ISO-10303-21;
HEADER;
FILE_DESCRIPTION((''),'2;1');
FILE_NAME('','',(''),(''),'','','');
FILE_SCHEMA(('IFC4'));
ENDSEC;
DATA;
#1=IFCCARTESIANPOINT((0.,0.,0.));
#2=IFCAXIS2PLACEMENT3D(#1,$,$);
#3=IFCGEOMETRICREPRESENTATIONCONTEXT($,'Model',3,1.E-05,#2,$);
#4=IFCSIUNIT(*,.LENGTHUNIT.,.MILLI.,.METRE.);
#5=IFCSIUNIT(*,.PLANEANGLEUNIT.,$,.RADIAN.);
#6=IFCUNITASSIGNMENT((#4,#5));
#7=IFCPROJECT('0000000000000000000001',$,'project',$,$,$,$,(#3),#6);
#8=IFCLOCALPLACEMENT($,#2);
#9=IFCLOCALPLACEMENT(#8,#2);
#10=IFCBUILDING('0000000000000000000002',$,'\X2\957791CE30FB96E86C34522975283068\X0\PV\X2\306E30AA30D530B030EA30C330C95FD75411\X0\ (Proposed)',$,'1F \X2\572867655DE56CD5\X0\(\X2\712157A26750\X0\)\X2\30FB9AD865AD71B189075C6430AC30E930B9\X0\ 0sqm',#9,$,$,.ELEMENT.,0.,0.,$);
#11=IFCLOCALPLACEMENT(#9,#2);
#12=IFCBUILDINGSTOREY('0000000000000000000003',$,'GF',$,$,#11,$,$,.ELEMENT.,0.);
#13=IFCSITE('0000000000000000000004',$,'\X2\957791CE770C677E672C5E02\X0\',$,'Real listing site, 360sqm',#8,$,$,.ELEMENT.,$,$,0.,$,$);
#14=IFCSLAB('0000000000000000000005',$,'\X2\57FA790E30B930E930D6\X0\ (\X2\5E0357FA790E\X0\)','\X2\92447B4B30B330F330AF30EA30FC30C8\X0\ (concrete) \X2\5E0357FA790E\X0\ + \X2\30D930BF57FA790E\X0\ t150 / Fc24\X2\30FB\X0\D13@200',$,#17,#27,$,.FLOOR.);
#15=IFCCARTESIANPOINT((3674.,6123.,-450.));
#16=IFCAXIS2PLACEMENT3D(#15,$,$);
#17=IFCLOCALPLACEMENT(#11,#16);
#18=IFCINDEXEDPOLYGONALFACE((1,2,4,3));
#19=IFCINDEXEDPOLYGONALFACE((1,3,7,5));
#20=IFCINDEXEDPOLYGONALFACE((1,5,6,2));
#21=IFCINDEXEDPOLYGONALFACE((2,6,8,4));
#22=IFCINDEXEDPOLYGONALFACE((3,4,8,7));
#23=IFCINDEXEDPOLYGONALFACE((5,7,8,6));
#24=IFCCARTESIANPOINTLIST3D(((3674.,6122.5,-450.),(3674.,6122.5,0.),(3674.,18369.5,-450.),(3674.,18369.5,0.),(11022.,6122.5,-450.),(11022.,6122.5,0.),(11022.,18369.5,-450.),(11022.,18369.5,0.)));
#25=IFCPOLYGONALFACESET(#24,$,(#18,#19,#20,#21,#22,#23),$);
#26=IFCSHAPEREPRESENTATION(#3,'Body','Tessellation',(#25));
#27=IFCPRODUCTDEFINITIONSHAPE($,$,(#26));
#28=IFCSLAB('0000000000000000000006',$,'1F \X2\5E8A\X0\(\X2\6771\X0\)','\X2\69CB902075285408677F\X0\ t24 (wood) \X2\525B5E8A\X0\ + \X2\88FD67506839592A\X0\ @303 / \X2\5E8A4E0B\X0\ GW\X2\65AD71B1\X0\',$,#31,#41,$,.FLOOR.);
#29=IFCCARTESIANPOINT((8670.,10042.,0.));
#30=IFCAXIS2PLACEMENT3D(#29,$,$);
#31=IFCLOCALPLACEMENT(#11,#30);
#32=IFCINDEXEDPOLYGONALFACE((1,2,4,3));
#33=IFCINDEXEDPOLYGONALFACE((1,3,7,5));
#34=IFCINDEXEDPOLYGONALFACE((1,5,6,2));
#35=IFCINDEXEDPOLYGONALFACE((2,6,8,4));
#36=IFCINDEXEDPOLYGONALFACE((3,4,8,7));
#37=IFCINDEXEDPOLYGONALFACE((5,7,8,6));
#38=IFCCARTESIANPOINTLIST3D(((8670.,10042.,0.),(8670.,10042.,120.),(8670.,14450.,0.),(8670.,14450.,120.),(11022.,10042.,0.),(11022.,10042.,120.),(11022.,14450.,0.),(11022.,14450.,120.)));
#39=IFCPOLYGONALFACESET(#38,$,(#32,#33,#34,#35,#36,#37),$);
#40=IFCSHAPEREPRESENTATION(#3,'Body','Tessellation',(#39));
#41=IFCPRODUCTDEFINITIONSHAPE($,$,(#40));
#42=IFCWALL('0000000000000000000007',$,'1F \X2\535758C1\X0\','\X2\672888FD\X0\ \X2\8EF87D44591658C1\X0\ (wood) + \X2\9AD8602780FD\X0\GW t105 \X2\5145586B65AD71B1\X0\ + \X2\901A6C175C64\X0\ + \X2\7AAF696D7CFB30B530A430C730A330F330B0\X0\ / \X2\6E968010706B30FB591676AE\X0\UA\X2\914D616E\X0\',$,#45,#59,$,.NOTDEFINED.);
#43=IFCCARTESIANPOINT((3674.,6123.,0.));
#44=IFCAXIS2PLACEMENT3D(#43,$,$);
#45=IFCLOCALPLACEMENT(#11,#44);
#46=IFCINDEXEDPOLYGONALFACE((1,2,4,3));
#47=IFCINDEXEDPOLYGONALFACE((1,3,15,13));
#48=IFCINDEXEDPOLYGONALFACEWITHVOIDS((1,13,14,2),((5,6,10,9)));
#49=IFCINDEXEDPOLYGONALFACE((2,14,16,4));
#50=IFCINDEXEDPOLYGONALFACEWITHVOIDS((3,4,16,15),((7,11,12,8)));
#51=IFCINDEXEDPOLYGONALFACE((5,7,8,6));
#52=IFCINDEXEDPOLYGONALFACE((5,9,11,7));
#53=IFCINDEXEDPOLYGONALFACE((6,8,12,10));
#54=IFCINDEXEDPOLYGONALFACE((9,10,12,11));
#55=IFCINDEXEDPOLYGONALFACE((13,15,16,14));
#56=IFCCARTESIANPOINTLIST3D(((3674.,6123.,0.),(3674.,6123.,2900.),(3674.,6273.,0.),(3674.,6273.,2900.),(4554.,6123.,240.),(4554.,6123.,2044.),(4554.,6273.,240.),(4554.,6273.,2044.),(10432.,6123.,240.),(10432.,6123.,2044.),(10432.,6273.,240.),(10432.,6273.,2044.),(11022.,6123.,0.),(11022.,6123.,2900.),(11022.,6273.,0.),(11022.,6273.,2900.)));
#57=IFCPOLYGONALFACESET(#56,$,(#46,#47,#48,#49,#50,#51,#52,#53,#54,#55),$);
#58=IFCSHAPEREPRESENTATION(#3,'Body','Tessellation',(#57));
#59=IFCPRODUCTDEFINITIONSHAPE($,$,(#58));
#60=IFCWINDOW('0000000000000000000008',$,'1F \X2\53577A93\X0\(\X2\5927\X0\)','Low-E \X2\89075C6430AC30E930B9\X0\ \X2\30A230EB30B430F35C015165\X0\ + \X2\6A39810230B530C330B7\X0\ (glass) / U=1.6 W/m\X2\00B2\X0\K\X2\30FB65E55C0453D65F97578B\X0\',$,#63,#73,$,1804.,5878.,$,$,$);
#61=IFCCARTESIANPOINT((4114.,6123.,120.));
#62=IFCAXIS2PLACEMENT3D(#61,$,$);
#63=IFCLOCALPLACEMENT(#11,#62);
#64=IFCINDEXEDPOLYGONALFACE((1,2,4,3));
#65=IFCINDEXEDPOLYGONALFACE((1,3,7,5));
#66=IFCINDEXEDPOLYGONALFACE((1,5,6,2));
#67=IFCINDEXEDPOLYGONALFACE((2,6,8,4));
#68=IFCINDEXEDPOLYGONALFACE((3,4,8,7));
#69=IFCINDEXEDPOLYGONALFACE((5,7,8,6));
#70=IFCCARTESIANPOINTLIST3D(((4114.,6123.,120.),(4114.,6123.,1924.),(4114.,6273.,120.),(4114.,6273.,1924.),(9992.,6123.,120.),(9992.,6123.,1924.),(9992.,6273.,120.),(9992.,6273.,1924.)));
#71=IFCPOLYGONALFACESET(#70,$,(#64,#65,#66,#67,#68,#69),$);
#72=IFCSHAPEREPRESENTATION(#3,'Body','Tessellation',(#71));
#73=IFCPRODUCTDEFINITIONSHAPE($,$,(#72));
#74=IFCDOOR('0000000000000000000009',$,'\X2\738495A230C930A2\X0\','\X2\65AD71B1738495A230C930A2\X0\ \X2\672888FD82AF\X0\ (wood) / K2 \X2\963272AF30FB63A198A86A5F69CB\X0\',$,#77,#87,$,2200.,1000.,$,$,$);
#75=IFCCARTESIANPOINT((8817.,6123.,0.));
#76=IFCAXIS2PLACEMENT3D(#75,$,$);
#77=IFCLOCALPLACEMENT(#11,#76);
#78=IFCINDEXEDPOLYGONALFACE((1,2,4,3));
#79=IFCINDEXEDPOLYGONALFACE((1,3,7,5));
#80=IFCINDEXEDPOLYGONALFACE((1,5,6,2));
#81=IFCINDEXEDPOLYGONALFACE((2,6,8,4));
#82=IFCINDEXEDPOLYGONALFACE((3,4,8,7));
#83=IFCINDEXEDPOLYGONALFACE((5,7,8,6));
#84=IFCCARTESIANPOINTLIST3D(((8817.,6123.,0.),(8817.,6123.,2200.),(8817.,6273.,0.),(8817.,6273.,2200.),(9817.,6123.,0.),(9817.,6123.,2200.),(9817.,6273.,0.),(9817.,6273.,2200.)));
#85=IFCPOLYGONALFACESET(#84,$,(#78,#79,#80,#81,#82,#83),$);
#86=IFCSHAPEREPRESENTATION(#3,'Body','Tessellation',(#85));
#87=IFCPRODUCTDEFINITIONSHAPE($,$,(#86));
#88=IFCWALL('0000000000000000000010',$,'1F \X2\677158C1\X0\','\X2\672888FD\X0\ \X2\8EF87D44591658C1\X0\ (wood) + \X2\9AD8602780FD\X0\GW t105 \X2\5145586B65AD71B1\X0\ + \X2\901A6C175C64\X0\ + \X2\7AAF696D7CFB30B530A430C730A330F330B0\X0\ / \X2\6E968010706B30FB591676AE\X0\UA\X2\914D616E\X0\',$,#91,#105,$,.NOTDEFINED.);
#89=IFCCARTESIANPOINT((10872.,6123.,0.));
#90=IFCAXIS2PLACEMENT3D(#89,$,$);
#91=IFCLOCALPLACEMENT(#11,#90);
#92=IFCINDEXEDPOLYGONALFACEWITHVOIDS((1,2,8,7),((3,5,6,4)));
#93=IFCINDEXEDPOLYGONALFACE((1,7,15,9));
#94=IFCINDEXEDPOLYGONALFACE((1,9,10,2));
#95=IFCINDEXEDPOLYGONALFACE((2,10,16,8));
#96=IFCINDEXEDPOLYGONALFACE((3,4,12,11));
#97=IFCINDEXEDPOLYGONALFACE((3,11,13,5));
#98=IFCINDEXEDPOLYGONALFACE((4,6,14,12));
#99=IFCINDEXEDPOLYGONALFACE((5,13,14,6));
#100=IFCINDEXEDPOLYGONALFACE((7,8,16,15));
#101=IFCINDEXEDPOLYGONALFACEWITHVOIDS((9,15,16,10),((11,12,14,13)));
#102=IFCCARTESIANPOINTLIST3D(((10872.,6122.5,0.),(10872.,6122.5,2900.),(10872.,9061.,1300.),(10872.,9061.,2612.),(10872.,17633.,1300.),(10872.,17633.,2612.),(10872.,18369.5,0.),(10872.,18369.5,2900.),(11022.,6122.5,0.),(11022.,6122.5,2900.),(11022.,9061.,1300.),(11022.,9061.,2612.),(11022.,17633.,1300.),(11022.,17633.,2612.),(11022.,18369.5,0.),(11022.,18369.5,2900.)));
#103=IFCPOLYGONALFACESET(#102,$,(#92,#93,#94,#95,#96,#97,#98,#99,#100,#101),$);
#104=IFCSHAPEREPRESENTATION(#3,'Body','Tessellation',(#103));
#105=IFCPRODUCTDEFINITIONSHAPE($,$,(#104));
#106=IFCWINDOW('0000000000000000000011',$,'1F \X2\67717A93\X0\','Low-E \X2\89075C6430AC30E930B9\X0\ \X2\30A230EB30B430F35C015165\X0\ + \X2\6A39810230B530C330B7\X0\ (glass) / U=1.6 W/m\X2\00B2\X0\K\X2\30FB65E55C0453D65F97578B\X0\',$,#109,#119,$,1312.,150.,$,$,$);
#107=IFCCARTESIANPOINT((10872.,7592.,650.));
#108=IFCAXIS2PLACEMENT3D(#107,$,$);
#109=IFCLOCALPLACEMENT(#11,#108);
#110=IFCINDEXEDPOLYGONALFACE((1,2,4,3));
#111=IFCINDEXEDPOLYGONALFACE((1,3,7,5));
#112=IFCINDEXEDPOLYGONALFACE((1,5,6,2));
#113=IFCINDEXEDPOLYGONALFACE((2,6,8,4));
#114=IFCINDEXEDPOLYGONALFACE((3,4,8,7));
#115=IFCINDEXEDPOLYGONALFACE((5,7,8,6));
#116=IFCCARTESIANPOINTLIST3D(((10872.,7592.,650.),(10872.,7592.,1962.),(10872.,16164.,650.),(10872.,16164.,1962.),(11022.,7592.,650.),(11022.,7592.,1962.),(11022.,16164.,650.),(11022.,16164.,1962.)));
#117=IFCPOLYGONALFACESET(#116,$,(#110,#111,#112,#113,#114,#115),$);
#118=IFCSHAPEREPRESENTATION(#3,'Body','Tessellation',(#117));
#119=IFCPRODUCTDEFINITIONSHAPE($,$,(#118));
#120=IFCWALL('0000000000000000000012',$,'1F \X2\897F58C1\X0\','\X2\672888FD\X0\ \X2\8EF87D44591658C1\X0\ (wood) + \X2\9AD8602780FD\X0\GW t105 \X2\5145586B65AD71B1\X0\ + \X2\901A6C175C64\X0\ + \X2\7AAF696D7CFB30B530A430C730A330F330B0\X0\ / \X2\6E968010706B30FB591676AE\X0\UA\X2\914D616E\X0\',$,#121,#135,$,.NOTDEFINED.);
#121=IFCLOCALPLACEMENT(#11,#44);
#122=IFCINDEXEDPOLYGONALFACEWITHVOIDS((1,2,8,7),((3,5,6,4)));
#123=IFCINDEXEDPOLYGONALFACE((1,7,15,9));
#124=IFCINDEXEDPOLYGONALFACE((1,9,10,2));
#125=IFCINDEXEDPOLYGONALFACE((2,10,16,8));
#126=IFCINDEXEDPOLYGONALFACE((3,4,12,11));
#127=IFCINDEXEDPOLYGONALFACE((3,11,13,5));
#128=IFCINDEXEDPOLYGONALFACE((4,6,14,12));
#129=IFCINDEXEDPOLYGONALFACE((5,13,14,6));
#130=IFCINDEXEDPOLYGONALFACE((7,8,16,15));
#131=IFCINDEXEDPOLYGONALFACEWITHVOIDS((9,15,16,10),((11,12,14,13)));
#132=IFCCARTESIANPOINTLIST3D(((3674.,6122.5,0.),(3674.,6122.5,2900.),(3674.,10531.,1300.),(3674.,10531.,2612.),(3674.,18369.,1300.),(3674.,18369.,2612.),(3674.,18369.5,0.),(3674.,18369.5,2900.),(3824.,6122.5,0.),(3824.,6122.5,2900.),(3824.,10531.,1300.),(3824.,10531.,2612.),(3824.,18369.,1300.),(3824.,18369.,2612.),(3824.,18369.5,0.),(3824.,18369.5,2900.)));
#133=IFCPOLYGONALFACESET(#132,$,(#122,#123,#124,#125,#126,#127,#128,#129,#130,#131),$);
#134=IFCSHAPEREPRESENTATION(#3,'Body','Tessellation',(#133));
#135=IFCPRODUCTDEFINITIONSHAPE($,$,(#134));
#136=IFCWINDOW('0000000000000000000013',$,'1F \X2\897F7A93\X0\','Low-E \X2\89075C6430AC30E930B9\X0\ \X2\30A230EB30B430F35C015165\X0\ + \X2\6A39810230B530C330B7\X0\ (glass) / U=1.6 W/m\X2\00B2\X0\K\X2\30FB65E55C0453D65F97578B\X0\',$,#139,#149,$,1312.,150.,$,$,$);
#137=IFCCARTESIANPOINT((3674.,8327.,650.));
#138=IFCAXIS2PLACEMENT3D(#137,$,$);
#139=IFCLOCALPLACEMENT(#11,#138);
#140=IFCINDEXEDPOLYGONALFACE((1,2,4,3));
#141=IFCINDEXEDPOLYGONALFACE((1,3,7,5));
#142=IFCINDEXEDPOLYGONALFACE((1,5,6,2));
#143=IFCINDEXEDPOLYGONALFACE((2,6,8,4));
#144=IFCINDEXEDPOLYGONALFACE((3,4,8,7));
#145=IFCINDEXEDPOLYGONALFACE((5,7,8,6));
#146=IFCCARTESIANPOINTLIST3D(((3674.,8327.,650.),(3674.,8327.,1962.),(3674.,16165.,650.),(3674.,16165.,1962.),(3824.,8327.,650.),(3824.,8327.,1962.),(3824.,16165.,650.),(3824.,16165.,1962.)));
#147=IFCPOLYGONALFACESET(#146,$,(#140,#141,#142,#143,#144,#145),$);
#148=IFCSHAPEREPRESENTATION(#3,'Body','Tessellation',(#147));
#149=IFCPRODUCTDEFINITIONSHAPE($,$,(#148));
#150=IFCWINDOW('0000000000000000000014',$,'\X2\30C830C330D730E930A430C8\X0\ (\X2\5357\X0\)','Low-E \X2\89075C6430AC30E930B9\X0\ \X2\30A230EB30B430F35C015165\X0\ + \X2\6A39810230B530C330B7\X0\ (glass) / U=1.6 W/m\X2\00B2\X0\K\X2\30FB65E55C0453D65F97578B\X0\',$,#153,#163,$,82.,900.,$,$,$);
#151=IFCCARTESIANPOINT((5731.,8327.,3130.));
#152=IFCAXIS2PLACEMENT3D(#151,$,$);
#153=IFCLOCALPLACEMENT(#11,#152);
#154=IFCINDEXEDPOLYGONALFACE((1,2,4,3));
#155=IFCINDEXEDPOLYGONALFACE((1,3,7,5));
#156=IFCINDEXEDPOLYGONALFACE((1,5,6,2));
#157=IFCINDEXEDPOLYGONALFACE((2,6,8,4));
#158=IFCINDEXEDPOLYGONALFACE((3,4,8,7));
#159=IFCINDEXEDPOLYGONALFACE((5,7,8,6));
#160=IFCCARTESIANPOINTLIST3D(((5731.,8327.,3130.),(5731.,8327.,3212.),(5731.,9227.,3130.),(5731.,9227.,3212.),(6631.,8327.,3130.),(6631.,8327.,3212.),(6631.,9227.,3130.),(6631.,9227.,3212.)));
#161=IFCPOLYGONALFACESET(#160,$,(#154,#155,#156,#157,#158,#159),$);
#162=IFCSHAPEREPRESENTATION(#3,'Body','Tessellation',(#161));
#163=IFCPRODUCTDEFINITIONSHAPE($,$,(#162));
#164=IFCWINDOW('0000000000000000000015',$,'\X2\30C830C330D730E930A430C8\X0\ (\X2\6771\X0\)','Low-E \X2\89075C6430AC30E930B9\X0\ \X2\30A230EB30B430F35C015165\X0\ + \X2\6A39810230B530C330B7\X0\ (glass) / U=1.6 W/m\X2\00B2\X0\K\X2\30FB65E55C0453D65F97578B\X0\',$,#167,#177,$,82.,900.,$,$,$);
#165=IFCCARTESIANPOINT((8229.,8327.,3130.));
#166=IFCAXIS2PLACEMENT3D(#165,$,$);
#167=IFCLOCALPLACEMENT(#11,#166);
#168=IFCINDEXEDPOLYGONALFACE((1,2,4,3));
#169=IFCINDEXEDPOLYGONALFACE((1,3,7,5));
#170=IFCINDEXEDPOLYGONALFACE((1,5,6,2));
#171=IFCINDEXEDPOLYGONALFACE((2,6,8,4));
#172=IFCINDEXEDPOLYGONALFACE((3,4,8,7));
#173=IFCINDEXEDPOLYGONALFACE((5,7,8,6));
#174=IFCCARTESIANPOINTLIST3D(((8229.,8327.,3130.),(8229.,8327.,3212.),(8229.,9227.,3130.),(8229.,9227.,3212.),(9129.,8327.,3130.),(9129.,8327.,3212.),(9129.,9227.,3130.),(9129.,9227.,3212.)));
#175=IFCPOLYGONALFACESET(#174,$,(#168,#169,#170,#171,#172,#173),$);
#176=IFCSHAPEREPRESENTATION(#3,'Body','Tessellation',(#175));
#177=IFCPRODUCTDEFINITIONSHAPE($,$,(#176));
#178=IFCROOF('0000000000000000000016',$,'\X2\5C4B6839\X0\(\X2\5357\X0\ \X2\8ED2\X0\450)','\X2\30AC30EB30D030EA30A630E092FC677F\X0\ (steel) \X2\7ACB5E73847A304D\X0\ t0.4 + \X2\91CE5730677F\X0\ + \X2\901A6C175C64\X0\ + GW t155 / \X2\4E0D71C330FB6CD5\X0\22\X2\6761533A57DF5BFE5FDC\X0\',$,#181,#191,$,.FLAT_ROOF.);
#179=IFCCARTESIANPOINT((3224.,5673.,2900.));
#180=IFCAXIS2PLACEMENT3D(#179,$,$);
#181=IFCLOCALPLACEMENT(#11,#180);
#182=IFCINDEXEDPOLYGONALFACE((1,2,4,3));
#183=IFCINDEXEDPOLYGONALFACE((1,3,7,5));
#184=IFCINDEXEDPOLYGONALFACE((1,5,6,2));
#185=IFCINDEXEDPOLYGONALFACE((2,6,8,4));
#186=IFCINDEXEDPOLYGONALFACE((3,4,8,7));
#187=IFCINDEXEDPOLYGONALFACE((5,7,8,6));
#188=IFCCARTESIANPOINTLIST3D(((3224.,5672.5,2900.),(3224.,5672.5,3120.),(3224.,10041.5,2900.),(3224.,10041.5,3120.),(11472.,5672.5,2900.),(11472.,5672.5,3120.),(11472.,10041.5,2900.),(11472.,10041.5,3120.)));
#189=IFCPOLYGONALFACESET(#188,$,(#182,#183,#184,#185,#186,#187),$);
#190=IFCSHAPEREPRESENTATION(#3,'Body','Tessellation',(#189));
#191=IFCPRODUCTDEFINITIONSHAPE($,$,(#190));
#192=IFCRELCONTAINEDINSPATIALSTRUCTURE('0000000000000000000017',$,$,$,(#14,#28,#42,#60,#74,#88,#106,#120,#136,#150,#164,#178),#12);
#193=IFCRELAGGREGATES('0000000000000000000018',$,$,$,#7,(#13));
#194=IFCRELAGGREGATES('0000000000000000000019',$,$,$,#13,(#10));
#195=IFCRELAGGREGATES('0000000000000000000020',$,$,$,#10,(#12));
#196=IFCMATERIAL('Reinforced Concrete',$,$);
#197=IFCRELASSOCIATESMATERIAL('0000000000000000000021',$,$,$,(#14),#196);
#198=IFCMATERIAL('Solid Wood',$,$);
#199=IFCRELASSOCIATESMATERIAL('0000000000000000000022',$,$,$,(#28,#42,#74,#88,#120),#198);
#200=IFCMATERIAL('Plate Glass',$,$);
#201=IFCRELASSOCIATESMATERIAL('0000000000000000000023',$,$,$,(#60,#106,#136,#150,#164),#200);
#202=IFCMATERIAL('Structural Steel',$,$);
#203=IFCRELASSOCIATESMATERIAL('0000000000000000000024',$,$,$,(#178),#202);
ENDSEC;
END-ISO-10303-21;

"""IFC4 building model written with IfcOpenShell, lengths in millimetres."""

from ifc_helpers import new_model, si_unit, frame, frame_2d, origin, place, context, project, spatial, rectangle, extrude, material, element, fill, save


model = new_model("IFC4")

# Units and contexts
model_context = context("Model", 3, precision=1e-05, world=origin())
ifc_project = project(units=[si_unit("LENGTHUNIT", "METRE", prefix="MILLI"), si_unit("PLANEANGLEUNIT", "RADIAN")], contexts=[model_context])

# Site, building, storey
site_placement = place(None, origin())
site = spatial("IfcSite", under=ifc_project, at=site_placement, Name="長野県松本市", ObjectType="Real listing site, 360sqm", CompositionType="ELEMENT", RefElevation=0.0)
building_placement = place(site_placement, origin())
building = spatial("IfcBuilding", under=site, at=building_placement, Name="長野・雨水利用とPVのオフグリッド志向 (Proposed)", ObjectType="1F 在来工法(無垢材)・高断熱複層ガラス 0sqm", CompositionType="ELEMENT", ElevationOfRefHeight=0.0, ElevationOfTerrain=0.0)
storey_placement = place(building_placement, origin())
storey = spatial("IfcBuildingStorey", under=building, at=storey_placement, Name="GF", CompositionType="ELEMENT", Elevation=0.0)

# Slabs
ifc_material_1 = material(Name="Reinforced Concrete")
slab_1_placement = place(storey_placement, frame((3674.0, 6123.0, -450.0)))
element("IfcSlab", 1, at=slab_1_placement, inside=storey, material=ifc_material_1, Name="基礎スラブ (布基礎)", Description="鉄筋コンクリート (concrete) 布基礎 + ベタ基礎 t150 / Fc24・D13@200", PredefinedType="FLOOR", context=model_context, shape_type="SweptSolid", body=[
    extrude(rectangle(XDim=7348.0, YDim=12247.0, at=frame_2d((3674.0, 6123.0))), frame((3674.0, 6123.0, -450.0)), (0.0, 0.0, 1.0), 450.0),
])
ifc_material_2 = material(Name="Solid Wood")
slab_2_placement = place(storey_placement, frame((8670.0, 10042.0, 0.0)))
element("IfcSlab", 2, at=slab_2_placement, inside=storey, material=ifc_material_2, Name="1F 床(東)", Description="構造用合板 t24 (wood) 剛床 + 製材根太 @303 / 床下 GW断熱", PredefinedType="FLOOR", context=model_context, shape_type="SweptSolid", body=[
    extrude(rectangle(XDim=2352.0, YDim=4408.0, at=frame_2d((1176.0, 2204.0))), frame((8670.0, 10042.0, 0.0)), (0.0, 0.0, 1.0), 120.0),
])

# Wall, openings, window, door
wall_1_placement = place(storey_placement, frame((3674.0, 6123.0, 0.0)))
wall_1 = element("IfcWall", 3, at=wall_1_placement, inside=storey, material=ifc_material_2, Name="1F 南壁", Description="木製 軸組外壁 (wood) + 高性能GW t105 充填断熱 + 通気層 + 窯業系サイディング / 準耐火・外皮UA配慮", PredefinedType="NOTDEFINED", context=model_context, shape_type="SweptSolid", body=[
    extrude(rectangle(XDim=7348.0, YDim=150.0, at=frame_2d((3674.0, 75.0))), frame((3674.0, 6123.0, 0.0)), (0.0, 0.0, 1.0), 2900.0),
])
opening_1_placement = place(storey_placement, frame((4114.0, 6123.0, 120.0)))
opening_1 = element("IfcOpeningElement", 4, at=opening_1_placement, cuts=wall_1, PredefinedType="NOTDEFINED", context=model_context, shape_type="SweptSolid", body=[
    extrude(rectangle(XDim=5878.0, YDim=150.0, at=frame_2d((2939.0, 75.0))), frame((4114.0, 6123.0, 120.0)), (0.0, 0.0, 1.0), 1804.0),
])
opening_2_placement = place(storey_placement, frame((8817.0, 6123.0, 0.0)))
opening_2 = element("IfcOpeningElement", 5, at=opening_2_placement, cuts=wall_1, PredefinedType="NOTDEFINED", context=model_context, shape_type="SweptSolid", body=[
    extrude(rectangle(XDim=1000.0, YDim=150.0, at=frame_2d((500.0, 75.0))), frame((8817.0, 6123.0, 0.0)), (0.0, 0.0, 1.0), 2200.0),
])
ifc_material_3 = material(Name="Plate Glass")
window_1_placement = place(storey_placement, frame((4114.0, 6123.0, 120.0)))
window_1 = element("IfcWindow", 6, at=window_1_placement, inside=storey, material=ifc_material_3, Name="1F 南窓(大)", Description="Low-E 複層ガラス アルゴン封入 + 樹脂サッシ (glass) / U=1.6 W/m²K・日射取得型", OverallHeight=1804.0, OverallWidth=5878.0, context=model_context, shape_type="SweptSolid", body=[
    extrude(rectangle(XDim=5878.0, YDim=150.0, at=frame_2d((2939.0, 75.0))), frame((4114.0, 6123.0, 120.0)), (0.0, 0.0, 1.0), 1804.0),
])
fill(opening_1, window_1)
door_placement = place(storey_placement, frame((8817.0, 6123.0, 0.0)))
door = element("IfcDoor", 7, at=door_placement, inside=storey, material=ifc_material_2, Name="玄関ドア", Description="断熱玄関ドア 木製芯 (wood) / K2 防犯・採風機構", OverallHeight=2200.0, OverallWidth=1000.0, context=model_context, shape_type="SweptSolid", body=[
    extrude(rectangle(XDim=1000.0, YDim=150.0, at=frame_2d((500.0, 75.0))), frame((8817.0, 6123.0, 0.0)), (0.0, 0.0, 1.0), 2200.0),
])
fill(opening_2, door)

# Walls, openings, windows
wall_2_placement = place(storey_placement, frame((10872.0, 6123.0, 0.0)))
wall_2 = element("IfcWall", 8, at=wall_2_placement, inside=storey, material=ifc_material_2, Name="1F 東壁", Description="木製 軸組外壁 (wood) + 高性能GW t105 充填断熱 + 通気層 + 窯業系サイディング / 準耐火・外皮UA配慮", PredefinedType="NOTDEFINED", context=model_context, shape_type="SweptSolid", body=[
    extrude(rectangle(XDim=150.0, YDim=12247.0, at=frame_2d((75.0, 6123.0))), frame((10872.0, 6123.0, 0.0)), (0.0, 0.0, 1.0), 2900.0),
])
opening_3_placement = place(storey_placement, frame((10872.0, 7592.0, 650.0)))
opening_3 = element("IfcOpeningElement", 9, at=opening_3_placement, cuts=wall_2, PredefinedType="NOTDEFINED", context=model_context, shape_type="SweptSolid", body=[
    extrude(rectangle(XDim=150.0, YDim=8572.0, at=frame_2d((75.0, 4286.0))), frame((10872.0, 7592.0, 650.0)), (0.0, 0.0, 1.0), 1312.0),
])
window_2_placement = place(storey_placement, frame((10872.0, 7592.0, 650.0)))
window_2 = element("IfcWindow", 10, at=window_2_placement, inside=storey, material=ifc_material_3, Name="1F 東窓", Description="Low-E 複層ガラス アルゴン封入 + 樹脂サッシ (glass) / U=1.6 W/m²K・日射取得型", OverallHeight=1312.0, OverallWidth=150.0, context=model_context, shape_type="SweptSolid", body=[
    extrude(rectangle(XDim=150.0, YDim=8572.0, at=frame_2d((75.0, 4286.0))), frame((10872.0, 7592.0, 650.0)), (0.0, 0.0, 1.0), 1312.0),
])
fill(opening_3, window_2)
wall_3_placement = place(storey_placement, frame((3674.0, 6123.0, 0.0)))
wall_3 = element("IfcWall", 11, at=wall_3_placement, inside=storey, material=ifc_material_2, Name="1F 西壁", Description="木製 軸組外壁 (wood) + 高性能GW t105 充填断熱 + 通気層 + 窯業系サイディング / 準耐火・外皮UA配慮", PredefinedType="NOTDEFINED", context=model_context, shape_type="SweptSolid", body=[
    extrude(rectangle(XDim=150.0, YDim=12247.0, at=frame_2d((75.0, 6123.0))), frame((3674.0, 6123.0, 0.0)), (0.0, 0.0, 1.0), 2900.0),
])
opening_4_placement = place(storey_placement, frame((3674.0, 8327.0, 650.0)))
opening_4 = element("IfcOpeningElement", 12, at=opening_4_placement, cuts=wall_3, PredefinedType="NOTDEFINED", context=model_context, shape_type="SweptSolid", body=[
    extrude(rectangle(XDim=150.0, YDim=7838.0, at=frame_2d((75.0, 3919.0))), frame((3674.0, 8327.0, 650.0)), (0.0, 0.0, 1.0), 1312.0),
])
window_3_placement = place(storey_placement, frame((3674.0, 8327.0, 650.0)))
window_3 = element("IfcWindow", 13, at=window_3_placement, inside=storey, material=ifc_material_3, Name="1F 西窓", Description="Low-E 複層ガラス アルゴン封入 + 樹脂サッシ (glass) / U=1.6 W/m²K・日射取得型", OverallHeight=1312.0, OverallWidth=150.0, context=model_context, shape_type="SweptSolid", body=[
    extrude(rectangle(XDim=150.0, YDim=7838.0, at=frame_2d((75.0, 3919.0))), frame((3674.0, 8327.0, 650.0)), (0.0, 0.0, 1.0), 1312.0),
])
fill(opening_4, window_3)

# Windows
window_4_placement = place(storey_placement, frame((5731.0, 8327.0, 3130.0)))
element("IfcWindow", 14, at=window_4_placement, inside=storey, material=ifc_material_3, Name="トップライト (南)", Description="Low-E 複層ガラス アルゴン封入 + 樹脂サッシ (glass) / U=1.6 W/m²K・日射取得型", OverallHeight=82.0, OverallWidth=900.0, context=model_context, shape_type="SweptSolid", body=[
    extrude(rectangle(XDim=900.0, YDim=900.0, at=frame_2d((450.0, 450.0))), frame((5731.0, 8327.0, 3130.0)), (0.0, 0.0, 1.0), 82.0),
])
window_5_placement = place(storey_placement, frame((8229.0, 8327.0, 3130.0)))
element("IfcWindow", 15, at=window_5_placement, inside=storey, material=ifc_material_3, Name="トップライト (東)", Description="Low-E 複層ガラス アルゴン封入 + 樹脂サッシ (glass) / U=1.6 W/m²K・日射取得型", OverallHeight=82.0, OverallWidth=900.0, context=model_context, shape_type="SweptSolid", body=[
    extrude(rectangle(XDim=900.0, YDim=900.0, at=frame_2d((450.0, 450.0))), frame((8229.0, 8327.0, 3130.0)), (0.0, 0.0, 1.0), 82.0),
])

# Roof
ifc_material_4 = material(Name="Structural Steel")
roof_placement = place(storey_placement, frame((3224.0, 5673.0, 2900.0)))
element("IfcRoof", 16, at=roof_placement, inside=storey, material=ifc_material_4, Name="屋根(南 軒450)", Description="ガルバリウム鋼板 (steel) 立平葺き t0.4 + 野地板 + 通気層 + GW t155 / 不燃・法22条区域対応", PredefinedType="FLAT_ROOF", context=model_context, shape_type="SweptSolid", body=[
    extrude(rectangle(XDim=8248.0, YDim=4369.0, at=frame_2d((4124.0, 2184.0))), frame((3224.0, 5673.0, 2900.0)), (0.0, 0.0, 1.0), 220.0),
])

save(model, "model.ifc")
